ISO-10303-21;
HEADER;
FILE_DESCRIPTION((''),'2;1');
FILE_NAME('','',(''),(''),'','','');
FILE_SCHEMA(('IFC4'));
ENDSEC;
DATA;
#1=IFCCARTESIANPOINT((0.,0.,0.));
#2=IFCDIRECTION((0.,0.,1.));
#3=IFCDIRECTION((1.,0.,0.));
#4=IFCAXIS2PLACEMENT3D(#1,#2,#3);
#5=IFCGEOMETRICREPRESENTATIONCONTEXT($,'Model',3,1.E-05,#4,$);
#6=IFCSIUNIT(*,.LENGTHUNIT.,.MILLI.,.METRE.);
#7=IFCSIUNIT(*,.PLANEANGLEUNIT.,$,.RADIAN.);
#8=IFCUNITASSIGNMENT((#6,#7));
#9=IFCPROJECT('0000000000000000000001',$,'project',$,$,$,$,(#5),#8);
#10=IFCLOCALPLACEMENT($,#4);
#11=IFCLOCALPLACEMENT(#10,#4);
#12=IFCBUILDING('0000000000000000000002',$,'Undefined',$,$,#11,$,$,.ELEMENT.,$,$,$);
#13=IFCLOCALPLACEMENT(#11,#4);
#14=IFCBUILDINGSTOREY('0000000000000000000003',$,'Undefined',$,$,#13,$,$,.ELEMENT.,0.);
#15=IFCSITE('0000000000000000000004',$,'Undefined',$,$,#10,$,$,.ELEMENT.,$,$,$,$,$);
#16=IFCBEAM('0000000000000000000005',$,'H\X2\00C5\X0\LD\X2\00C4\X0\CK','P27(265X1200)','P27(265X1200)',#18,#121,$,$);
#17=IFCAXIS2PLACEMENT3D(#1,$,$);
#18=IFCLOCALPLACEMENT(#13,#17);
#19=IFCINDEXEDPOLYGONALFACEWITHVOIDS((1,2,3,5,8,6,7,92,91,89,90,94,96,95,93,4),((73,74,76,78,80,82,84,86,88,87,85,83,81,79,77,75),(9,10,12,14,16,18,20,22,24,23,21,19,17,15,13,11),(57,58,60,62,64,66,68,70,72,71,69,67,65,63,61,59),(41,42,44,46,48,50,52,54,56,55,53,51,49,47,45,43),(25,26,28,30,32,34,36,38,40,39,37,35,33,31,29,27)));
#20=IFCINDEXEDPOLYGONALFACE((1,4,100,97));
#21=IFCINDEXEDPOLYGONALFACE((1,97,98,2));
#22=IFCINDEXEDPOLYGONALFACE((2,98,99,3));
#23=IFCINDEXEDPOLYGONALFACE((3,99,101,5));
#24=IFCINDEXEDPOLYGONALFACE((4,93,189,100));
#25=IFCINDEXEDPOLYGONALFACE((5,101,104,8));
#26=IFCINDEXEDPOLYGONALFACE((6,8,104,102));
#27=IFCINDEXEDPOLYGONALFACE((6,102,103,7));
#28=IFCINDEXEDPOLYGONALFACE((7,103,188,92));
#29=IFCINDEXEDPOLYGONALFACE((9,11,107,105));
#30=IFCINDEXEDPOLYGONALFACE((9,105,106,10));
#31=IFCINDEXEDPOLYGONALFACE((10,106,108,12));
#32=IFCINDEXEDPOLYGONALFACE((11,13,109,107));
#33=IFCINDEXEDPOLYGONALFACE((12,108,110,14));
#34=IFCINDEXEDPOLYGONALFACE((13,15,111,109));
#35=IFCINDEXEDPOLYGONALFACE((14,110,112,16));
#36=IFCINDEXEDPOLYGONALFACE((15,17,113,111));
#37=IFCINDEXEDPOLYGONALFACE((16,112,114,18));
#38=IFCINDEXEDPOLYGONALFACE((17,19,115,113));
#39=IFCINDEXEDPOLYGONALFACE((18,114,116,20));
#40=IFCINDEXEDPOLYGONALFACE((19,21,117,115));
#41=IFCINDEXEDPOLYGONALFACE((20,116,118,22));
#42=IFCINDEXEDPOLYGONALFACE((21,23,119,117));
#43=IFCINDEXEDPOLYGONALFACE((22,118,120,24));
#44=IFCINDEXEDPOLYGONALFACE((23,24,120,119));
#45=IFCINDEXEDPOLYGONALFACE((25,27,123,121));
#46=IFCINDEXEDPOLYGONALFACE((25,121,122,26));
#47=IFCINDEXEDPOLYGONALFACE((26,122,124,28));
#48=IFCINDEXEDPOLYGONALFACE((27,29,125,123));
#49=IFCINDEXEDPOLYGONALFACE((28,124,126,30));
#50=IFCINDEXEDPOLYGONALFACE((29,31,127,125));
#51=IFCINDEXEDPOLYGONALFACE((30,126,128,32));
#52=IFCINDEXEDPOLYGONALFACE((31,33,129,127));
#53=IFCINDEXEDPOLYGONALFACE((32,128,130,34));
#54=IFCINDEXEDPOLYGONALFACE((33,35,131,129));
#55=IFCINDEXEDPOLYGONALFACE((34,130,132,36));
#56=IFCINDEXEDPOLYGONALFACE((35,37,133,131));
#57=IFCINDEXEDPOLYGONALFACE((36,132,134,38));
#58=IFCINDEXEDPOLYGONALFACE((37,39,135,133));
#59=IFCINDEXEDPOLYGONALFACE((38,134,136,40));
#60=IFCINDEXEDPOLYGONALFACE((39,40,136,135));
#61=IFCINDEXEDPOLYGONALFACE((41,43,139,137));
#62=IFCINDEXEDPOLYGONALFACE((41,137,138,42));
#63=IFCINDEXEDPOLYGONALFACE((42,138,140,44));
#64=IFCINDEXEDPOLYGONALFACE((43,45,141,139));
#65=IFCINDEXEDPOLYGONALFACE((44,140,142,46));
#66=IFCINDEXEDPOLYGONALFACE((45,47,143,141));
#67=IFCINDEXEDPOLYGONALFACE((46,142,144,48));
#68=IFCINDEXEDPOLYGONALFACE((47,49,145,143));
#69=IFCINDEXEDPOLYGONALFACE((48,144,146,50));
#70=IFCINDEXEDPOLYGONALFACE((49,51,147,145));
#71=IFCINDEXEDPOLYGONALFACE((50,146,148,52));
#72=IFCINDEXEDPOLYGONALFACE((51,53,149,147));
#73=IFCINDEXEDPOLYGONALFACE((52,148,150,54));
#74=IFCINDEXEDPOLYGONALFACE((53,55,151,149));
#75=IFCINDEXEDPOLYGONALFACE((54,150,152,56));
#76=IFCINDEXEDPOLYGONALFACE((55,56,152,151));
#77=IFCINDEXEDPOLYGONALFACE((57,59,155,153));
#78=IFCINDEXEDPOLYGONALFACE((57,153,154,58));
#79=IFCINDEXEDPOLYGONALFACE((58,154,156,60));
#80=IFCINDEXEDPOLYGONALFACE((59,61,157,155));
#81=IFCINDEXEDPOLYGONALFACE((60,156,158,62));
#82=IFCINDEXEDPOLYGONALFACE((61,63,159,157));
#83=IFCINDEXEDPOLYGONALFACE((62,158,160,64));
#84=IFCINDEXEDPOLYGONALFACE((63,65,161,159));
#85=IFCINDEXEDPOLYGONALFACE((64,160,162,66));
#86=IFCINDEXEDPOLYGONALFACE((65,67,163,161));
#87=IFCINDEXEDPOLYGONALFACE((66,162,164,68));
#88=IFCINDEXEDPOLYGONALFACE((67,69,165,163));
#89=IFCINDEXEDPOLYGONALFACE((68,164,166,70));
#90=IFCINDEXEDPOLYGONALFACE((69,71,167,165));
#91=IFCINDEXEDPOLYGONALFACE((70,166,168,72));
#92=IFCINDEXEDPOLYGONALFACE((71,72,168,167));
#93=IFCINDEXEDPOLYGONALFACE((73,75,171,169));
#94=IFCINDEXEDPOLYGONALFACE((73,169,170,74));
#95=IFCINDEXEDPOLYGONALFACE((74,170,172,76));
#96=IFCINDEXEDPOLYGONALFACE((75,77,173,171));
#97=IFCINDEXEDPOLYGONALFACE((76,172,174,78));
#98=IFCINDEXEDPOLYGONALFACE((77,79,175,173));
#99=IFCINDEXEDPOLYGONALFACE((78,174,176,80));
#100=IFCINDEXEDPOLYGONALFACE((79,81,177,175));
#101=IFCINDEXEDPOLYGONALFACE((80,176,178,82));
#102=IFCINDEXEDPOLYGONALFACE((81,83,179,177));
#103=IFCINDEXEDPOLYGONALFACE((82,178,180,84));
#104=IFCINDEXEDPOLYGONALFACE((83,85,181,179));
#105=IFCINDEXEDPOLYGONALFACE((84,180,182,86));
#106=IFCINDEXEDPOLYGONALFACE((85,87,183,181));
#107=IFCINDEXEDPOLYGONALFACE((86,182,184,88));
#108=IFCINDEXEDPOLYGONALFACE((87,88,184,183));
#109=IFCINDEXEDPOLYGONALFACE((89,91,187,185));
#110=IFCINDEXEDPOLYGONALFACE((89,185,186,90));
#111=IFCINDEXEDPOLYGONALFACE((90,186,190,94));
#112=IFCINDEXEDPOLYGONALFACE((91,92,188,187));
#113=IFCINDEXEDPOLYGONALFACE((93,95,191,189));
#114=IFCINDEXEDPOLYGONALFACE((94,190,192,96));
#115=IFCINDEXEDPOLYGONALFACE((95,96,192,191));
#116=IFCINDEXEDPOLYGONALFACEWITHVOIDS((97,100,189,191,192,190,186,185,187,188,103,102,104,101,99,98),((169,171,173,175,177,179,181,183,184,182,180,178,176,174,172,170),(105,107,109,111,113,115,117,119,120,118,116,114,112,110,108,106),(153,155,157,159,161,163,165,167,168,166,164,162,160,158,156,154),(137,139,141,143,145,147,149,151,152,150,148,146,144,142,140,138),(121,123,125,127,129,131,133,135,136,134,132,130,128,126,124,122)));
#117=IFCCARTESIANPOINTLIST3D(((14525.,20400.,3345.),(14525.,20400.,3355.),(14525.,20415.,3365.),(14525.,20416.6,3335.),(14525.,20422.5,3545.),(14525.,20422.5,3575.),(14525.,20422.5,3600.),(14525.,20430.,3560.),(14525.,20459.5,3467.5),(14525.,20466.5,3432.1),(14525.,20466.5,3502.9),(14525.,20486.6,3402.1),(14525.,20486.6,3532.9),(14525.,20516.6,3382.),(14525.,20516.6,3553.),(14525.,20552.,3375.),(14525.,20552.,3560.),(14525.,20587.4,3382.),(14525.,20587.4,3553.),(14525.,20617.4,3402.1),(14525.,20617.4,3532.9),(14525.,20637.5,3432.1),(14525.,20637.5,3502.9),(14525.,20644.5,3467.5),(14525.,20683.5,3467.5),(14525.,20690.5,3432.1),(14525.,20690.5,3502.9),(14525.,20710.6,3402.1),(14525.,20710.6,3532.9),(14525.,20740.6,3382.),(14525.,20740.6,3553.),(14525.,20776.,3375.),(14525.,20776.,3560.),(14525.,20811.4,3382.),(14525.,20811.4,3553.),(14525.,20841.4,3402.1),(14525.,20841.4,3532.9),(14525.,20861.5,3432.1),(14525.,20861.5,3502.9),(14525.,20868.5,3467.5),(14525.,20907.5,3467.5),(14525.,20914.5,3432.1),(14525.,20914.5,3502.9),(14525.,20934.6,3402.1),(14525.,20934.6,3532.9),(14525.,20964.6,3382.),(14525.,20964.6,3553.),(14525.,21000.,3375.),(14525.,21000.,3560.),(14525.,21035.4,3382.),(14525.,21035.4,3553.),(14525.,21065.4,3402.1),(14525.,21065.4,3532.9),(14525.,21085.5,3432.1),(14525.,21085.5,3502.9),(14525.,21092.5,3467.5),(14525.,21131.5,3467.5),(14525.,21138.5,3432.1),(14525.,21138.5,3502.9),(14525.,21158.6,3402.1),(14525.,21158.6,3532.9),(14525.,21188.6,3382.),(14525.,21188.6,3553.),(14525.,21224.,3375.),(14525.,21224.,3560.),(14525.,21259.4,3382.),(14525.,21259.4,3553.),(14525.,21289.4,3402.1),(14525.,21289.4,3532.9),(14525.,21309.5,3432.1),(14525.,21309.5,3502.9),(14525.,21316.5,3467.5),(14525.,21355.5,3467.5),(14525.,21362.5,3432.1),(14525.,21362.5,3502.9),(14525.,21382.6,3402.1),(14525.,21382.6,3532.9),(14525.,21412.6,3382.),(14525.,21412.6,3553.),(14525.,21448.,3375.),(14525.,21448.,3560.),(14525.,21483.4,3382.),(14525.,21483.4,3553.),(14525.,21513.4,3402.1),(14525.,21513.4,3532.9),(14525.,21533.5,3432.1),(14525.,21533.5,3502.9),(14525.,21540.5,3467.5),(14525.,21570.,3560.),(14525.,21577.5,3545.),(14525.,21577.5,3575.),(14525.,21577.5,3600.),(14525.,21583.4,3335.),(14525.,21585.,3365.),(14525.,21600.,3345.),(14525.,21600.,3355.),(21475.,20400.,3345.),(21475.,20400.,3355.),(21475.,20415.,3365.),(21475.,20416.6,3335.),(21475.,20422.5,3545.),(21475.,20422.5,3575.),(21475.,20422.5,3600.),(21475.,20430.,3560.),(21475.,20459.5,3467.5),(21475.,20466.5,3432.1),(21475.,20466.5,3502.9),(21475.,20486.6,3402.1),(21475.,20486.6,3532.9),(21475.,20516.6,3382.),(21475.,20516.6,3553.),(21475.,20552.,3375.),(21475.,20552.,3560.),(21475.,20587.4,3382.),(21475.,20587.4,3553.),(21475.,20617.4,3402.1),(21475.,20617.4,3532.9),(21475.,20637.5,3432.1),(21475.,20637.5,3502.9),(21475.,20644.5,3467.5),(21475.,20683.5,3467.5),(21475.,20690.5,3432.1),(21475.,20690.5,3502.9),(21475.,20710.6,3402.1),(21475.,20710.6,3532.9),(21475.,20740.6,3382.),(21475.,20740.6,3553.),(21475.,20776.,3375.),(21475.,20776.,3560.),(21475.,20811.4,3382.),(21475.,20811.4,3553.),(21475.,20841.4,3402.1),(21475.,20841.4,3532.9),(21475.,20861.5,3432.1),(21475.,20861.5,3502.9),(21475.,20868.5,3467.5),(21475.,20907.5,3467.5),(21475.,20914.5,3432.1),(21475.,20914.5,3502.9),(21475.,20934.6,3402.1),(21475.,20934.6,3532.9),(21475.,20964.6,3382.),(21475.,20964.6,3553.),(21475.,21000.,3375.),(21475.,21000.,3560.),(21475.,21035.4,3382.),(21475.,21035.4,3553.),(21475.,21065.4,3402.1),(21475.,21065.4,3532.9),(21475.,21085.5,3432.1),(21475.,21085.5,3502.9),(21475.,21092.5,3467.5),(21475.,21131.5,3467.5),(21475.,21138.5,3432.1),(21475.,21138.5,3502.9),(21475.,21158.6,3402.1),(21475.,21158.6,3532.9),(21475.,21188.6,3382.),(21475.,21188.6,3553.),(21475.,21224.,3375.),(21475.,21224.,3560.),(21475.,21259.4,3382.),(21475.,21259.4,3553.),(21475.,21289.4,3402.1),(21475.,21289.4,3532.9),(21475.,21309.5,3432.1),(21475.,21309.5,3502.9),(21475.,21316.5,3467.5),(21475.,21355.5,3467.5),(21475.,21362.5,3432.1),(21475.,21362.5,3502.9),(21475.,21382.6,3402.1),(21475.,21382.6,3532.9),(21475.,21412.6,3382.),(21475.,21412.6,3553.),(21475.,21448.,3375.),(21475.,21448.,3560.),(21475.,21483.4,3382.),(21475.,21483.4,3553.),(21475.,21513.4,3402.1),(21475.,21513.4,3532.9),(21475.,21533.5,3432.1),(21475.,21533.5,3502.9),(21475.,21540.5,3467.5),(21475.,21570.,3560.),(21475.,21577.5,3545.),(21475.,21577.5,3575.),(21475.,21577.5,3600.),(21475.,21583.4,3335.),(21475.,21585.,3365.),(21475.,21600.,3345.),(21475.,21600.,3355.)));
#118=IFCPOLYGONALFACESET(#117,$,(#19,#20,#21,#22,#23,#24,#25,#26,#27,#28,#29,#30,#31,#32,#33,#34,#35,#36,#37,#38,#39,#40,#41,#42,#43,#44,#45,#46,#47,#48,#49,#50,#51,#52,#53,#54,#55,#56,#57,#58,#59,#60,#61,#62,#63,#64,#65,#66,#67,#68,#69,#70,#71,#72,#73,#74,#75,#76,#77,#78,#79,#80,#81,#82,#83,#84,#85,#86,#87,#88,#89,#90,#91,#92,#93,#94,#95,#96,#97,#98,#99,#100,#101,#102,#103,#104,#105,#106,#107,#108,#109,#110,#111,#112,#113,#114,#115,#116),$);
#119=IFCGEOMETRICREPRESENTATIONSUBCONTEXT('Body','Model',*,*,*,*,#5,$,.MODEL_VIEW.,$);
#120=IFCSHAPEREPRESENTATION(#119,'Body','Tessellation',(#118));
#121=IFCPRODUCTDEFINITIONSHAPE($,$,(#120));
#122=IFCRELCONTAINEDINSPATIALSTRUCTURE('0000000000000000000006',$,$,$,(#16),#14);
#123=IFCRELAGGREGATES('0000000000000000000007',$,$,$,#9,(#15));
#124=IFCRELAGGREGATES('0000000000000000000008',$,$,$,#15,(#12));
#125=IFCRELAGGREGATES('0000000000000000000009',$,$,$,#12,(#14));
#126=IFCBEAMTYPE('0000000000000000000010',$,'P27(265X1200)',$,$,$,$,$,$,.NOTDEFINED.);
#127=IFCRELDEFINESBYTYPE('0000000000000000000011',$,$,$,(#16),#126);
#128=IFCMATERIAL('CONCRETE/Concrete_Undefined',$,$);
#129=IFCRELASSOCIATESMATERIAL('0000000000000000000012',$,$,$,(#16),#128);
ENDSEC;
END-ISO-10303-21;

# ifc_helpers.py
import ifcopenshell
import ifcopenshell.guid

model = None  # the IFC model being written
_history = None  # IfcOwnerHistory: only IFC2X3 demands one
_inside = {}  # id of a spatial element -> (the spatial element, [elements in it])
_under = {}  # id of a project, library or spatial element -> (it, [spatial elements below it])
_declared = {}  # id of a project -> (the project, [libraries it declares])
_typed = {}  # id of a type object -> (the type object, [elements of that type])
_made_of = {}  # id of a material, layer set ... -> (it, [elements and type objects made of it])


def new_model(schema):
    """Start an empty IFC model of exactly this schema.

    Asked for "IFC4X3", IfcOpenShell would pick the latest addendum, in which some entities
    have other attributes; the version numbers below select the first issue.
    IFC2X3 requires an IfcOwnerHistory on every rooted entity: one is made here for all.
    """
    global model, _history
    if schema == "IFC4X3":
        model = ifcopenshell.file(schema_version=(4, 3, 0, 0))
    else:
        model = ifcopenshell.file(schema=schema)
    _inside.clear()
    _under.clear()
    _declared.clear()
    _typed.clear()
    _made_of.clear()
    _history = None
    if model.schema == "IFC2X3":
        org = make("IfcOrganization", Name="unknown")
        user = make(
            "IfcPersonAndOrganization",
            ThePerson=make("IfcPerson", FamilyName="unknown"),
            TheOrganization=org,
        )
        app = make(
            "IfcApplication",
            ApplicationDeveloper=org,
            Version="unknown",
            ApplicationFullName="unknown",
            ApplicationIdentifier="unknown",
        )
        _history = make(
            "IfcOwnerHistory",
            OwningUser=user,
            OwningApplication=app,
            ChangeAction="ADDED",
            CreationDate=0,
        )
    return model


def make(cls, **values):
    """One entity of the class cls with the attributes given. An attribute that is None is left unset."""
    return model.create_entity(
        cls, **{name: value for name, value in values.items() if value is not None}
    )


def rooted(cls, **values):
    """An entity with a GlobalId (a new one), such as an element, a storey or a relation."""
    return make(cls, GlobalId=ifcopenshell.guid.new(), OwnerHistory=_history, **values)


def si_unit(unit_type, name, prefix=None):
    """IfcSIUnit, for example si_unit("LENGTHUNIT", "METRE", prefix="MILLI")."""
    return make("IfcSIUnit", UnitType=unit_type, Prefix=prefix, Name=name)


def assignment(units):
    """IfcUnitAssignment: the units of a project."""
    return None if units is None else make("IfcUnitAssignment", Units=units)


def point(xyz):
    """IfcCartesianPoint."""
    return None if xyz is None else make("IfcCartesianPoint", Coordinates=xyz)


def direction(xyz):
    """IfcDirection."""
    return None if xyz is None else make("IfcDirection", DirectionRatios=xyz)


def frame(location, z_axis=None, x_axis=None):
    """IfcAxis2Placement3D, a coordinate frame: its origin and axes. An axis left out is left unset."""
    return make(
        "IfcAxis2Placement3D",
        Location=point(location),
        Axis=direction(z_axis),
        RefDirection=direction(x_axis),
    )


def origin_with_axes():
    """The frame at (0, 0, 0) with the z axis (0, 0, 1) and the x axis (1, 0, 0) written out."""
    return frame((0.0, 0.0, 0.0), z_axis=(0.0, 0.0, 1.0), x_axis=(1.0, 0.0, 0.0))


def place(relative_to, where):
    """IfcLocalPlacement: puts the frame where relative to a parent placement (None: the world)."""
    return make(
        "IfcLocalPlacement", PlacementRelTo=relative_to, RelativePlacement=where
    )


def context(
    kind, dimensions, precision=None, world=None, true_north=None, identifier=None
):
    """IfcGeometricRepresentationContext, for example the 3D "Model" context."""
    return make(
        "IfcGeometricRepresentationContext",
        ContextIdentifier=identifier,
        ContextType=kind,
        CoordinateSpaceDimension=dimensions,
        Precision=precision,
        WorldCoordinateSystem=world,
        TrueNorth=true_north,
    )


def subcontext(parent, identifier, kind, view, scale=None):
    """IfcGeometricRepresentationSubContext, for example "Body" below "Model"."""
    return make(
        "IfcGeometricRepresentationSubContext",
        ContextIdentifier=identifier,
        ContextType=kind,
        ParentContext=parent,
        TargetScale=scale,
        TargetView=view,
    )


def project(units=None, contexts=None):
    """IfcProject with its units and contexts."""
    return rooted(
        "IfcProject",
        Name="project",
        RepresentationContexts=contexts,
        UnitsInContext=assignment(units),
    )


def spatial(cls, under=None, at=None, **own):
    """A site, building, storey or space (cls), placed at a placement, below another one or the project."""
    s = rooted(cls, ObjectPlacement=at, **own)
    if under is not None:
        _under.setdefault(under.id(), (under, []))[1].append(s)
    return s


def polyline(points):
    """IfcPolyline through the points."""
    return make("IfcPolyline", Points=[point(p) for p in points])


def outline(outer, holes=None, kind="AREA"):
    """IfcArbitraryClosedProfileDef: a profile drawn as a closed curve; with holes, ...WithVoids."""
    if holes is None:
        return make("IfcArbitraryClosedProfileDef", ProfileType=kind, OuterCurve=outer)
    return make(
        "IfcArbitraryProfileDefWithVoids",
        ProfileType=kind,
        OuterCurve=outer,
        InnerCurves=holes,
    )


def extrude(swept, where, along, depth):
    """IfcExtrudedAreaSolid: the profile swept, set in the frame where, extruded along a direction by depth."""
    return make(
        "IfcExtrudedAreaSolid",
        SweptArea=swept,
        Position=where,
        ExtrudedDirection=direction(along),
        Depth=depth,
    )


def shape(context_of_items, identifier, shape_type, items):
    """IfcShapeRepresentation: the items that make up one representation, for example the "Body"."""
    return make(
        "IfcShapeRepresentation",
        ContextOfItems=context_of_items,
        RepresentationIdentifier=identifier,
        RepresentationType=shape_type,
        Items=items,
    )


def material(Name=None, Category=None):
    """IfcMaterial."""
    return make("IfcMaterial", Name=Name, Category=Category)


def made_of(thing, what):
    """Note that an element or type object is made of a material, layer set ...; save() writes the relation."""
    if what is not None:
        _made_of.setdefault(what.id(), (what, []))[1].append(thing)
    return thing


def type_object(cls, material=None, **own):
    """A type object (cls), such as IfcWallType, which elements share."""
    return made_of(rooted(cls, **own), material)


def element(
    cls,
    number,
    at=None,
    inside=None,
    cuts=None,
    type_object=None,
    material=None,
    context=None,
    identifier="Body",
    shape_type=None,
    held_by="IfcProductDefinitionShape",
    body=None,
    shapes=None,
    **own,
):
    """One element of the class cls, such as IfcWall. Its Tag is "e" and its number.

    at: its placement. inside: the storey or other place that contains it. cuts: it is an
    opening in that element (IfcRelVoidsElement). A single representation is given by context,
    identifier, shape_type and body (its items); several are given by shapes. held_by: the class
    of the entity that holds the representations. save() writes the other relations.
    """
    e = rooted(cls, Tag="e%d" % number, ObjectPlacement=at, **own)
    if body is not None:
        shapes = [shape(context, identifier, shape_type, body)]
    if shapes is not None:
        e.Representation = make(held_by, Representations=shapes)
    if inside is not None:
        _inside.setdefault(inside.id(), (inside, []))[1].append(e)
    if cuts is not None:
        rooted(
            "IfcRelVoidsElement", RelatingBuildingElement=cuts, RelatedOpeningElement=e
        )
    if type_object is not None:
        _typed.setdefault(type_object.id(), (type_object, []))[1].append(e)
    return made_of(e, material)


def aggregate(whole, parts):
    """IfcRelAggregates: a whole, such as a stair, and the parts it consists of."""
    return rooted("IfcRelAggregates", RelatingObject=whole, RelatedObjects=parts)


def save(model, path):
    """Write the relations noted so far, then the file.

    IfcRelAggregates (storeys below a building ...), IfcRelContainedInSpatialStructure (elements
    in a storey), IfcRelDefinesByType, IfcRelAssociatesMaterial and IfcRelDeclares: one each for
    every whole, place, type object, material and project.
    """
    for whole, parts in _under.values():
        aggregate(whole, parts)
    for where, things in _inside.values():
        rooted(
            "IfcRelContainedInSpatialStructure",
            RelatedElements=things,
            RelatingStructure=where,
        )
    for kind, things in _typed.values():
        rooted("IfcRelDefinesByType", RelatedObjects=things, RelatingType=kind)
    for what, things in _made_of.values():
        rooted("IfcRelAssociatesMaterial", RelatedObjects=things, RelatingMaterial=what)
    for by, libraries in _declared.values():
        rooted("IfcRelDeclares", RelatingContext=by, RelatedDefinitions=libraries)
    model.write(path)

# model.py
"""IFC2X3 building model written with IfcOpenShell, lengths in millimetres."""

from ifc_helpers import new_model, si_unit, frame, origin_with_axes, place, context, subcontext, project, spatial, polyline, outline, extrude, material, type_object, element, save


model = new_model("IFC2X3")

# Units and contexts
model_context = context("Model", 3, precision=1e-05, world=origin_with_axes())
body_context = subcontext(model_context, "Body", "Model", "MODEL_VIEW")
ifc_project = project(units=[si_unit("LENGTHUNIT", "METRE", prefix="MILLI"), si_unit("PLANEANGLEUNIT", "RADIAN")], contexts=[model_context])

# Site, building, storey
site_placement = place(None, origin_with_axes())
site = spatial("IfcSite", under=ifc_project, at=site_placement, Name="Undefined", CompositionType="ELEMENT")
building_placement = place(site_placement, origin_with_axes())
building = spatial("IfcBuilding", under=site, at=building_placement, Name="Undefined", CompositionType="ELEMENT")
storey_placement = place(building_placement, origin_with_axes())
storey = spatial("IfcBuildingStorey", under=building, at=storey_placement, Name="Undefined", CompositionType="ELEMENT", Elevation=0.0)

# Beam
ifc_material_1 = material(Name="CONCRETE/Concrete_Undefined")
beam_type_1 = type_object("IfcBeamType", Name="P27(265X1200)", PredefinedType="NOTDEFINED")
beam_1_placement = place(storey_placement, frame((14525.0, 21000.0, 3467.5), z_axis=(0.0, 0.0, 1.0), x_axis=(1.0, 0.0, 0.0)))
element("IfcBeam", 1, at=beam_1_placement, inside=storey, type_object=beam_type_1, material=ifc_material_1, Name="HÅLDÄCK", Description="P27(265X1200)", ObjectType="P27(265X1200)", context=body_context, shape_type="SweptSolid", body=[
    extrude(outline(polyline([(-583.4, -132.5), (-600.0, -122.5), (-600.0, -112.5), (-585.0, -102.5), (-577.5, 77.5), (-570.0, 92.5), (-577.5, 107.5), (-577.5, 132.5), (577.5, 132.5), (577.5, 107.5), (570.0, 92.5), (577.5, 77.5), (585.0, -102.5), (600.0, -112.5), (600.0, -122.5), (583.4, -132.5), (-583.4, -132.5)]), holes=[polyline([(-513.4, 65.4), (-533.5, 35.4), (-540.5, 0.0), (-533.5, -35.4), (-513.4, -65.4), (-483.4, -85.5), (-448.0, -92.5), (-412.6, -85.5), (-382.6, -65.4), (-362.5, -35.4), (-355.5, 0.0), (-362.5, 35.4), (-382.6, 65.4), (-412.6, 85.5), (-448.0, 92.5), (-483.4, 85.5), (-513.4, 65.4)]), polyline([(-289.4, 65.4), (-309.5, 35.4), (-316.5, 0.0), (-309.5, -35.4), (-289.4, -65.4), (-259.4, -85.5), (-224.0, -92.5), (-188.6, -85.5), (-158.6, -65.4), (-138.5, -35.4), (-131.5, 0.0), (-138.5, 35.4), (-158.6, 65.4), (-188.6, 85.5), (-224.0, 92.5), (-259.4, 85.5), (-289.4, 65.4)]), polyline([(-65.4, 65.4), (-85.5, 35.4), (-92.5, 0.0), (-85.5, -35.4), (-65.4, -65.4), (-35.4, -85.5), (0.0, -92.5), (35.4, -85.5), (65.4, -65.4), (85.5, -35.4), (92.5, 0.0), (85.5, 35.4), (65.4, 65.4), (35.4, 85.5), (0.0, 92.5), (-35.4, 85.5), (-65.4, 65.4)]), polyline([(158.6, 65.4), (138.5, 35.4), (131.5, 0.0), (138.5, -35.4), (158.6, -65.4), (188.6, -85.5), (224.0, -92.5), (259.4, -85.5), (289.4, -65.4), (309.5, -35.4), (316.5, 0.0), (309.5, 35.4), (289.4, 65.4), (259.4, 85.5), (224.0, 92.5), (188.6, 85.5), (158.6, 65.4)]), polyline([(382.6, 65.4), (362.5, 35.4), (355.5, 0.0), (362.5, -35.4), (382.6, -65.4), (412.6, -85.5), (448.0, -92.5), (483.4, -85.5), (513.4, -65.4), (533.5, -35.4), (540.5, 0.0), (533.5, 35.4), (513.4, 65.4), (483.4, 85.5), (448.0, 92.5), (412.6, 85.5), (382.6, 65.4)])]), frame((6950.0, 0.0, 0.0), z_axis=(-1.0, 0.0, 0.0), x_axis=(0.0, -1.0, 0.0)), (0.0, 0.0, 1.0), 6950.0),
])

save(model, "model.ifc")
